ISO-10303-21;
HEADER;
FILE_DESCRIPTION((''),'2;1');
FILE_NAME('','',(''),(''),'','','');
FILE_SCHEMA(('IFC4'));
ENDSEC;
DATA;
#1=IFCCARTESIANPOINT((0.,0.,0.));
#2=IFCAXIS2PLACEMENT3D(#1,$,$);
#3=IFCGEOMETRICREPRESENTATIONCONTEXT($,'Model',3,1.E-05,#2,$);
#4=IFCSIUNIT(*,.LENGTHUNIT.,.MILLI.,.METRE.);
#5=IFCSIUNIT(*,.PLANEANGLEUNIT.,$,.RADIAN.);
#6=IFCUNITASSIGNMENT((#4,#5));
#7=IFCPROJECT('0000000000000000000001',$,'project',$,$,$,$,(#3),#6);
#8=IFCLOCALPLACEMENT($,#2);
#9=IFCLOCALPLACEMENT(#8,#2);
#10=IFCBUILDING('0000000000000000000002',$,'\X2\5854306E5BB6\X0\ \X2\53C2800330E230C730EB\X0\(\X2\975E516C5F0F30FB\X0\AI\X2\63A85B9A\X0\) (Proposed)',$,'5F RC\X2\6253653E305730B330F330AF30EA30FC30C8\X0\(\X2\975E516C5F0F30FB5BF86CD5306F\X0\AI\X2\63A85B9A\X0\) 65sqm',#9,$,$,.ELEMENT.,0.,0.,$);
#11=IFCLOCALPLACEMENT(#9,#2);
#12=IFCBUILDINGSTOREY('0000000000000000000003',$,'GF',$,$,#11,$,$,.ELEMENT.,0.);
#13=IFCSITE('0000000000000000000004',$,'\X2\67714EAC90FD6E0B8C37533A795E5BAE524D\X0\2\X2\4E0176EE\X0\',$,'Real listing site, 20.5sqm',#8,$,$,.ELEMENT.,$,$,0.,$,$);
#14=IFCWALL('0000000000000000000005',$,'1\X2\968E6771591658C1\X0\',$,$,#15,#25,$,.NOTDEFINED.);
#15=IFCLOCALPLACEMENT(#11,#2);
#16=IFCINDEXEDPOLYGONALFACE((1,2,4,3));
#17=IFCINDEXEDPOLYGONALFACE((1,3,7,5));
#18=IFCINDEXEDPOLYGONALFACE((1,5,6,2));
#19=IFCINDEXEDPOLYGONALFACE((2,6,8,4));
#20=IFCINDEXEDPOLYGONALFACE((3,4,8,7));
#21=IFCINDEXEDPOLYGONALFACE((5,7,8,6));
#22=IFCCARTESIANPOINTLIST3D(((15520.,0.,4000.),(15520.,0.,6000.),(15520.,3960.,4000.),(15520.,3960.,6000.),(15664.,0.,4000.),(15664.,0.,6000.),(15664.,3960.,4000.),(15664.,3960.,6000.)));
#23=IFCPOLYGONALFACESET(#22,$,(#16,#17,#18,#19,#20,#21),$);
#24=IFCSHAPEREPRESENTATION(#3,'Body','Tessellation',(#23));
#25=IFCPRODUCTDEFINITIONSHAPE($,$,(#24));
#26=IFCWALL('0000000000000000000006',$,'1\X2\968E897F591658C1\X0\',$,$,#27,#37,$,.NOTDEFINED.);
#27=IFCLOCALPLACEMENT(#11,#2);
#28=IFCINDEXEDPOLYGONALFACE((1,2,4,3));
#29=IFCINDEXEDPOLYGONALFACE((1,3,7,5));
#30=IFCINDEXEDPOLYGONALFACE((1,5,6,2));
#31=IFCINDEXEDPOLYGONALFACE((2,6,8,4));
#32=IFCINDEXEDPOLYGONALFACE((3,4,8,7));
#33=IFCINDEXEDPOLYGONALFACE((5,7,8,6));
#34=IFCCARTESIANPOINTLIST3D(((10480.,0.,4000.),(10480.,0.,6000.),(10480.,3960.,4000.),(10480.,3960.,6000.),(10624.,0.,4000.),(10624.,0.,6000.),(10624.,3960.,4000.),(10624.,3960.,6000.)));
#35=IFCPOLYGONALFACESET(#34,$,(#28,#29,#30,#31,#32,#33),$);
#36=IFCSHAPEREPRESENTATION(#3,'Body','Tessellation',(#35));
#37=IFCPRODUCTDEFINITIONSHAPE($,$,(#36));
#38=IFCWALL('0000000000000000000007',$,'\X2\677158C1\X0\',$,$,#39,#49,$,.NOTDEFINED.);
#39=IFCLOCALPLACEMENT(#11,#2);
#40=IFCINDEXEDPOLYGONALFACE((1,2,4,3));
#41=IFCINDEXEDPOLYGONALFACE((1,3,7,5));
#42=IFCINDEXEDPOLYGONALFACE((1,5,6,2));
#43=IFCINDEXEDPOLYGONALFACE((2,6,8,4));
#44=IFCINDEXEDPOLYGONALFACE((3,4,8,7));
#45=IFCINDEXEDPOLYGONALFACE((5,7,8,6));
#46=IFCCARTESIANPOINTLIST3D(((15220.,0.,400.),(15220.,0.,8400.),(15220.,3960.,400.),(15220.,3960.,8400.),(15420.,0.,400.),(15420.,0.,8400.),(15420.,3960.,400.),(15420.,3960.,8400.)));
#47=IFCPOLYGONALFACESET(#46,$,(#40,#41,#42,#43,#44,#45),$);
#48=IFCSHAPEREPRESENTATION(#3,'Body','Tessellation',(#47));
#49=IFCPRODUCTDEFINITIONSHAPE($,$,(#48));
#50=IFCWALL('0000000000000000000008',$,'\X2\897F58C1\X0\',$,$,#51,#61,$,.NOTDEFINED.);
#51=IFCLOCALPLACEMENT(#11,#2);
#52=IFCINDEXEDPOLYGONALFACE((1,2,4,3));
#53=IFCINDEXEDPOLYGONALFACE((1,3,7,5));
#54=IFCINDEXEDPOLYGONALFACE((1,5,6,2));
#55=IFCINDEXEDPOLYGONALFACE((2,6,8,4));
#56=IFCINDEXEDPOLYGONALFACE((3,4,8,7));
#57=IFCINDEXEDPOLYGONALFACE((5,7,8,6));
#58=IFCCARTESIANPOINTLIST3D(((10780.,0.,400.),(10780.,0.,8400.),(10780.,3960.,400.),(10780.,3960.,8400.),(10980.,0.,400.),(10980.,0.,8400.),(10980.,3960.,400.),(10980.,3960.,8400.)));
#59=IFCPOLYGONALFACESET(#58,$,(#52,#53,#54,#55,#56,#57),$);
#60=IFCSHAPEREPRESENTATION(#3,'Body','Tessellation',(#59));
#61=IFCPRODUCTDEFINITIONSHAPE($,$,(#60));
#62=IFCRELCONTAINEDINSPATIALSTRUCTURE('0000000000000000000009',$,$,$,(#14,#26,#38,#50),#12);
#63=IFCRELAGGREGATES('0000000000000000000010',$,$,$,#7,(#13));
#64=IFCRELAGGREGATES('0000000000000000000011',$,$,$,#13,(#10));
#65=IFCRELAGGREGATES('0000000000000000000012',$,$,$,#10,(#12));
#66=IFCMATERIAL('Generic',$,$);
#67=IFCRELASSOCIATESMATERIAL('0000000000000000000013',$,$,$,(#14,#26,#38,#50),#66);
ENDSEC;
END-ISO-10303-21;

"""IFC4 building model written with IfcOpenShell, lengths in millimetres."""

from ifc_helpers import new_model, si_unit, frame, frame_2d, origin, place, context, project, spatial, rectangle, extrude, material, element, save


model = new_model("IFC4")

# Units and contexts
model_context = context("Model", 3, precision=1e-05, world=origin())
ifc_project = project(units=[si_unit("LENGTHUNIT", "METRE", prefix="MILLI"), si_unit("PLANEANGLEUNIT", "RADIAN")], contexts=[model_context])

# Site, building, storey
site_placement = place(None, origin())
site = spatial("IfcSite", under=ifc_project, at=site_placement, Name="東京都渋谷区神宮前2丁目", ObjectType="Real listing site, 20.5sqm", CompositionType="ELEMENT", RefElevation=0.0)
building_placement = place(site_placement, origin())
building = spatial("IfcBuilding", under=site, at=building_placement, Name="塔の家 参考モデル(非公式・AI推定) (Proposed)", ObjectType="5F RC打放しコンクリート(非公式・寸法はAI推定) 65sqm", CompositionType="ELEMENT", ElevationOfRefHeight=0.0, ElevationOfTerrain=0.0)
storey_placement = place(building_placement, origin())
storey = spatial("IfcBuildingStorey", under=building, at=storey_placement, Name="GF", CompositionType="ELEMENT", Elevation=0.0)

# Shared definitions
ifc_material = material(Name="Generic")

# Walls
wall_1_placement = place(storey_placement, frame((7760.0, 0.0, 2000.0)))
element("IfcWall", 1, at=wall_1_placement, inside=storey, material=ifc_material, Name="1階東外壁", PredefinedType="NOTDEFINED", context=model_context, shape_type="SweptSolid", body=[
    extrude(rectangle(XDim=144.0, YDim=3960.0, at=frame_2d((72.0, 1980.0))), frame((7760.0, 0.0, 2000.0)), (0.0, 0.0, 1.0), 2000.0),
])
wall_2_placement = place(storey_placement, frame((5240.0, 0.0, 2000.0)))
element("IfcWall", 2, at=wall_2_placement, inside=storey, material=ifc_material, Name="1階西外壁", PredefinedType="NOTDEFINED", context=model_context, shape_type="SweptSolid", body=[
    extrude(rectangle(XDim=144.0, YDim=3960.0, at=frame_2d((72.0, 1980.0))), frame((5240.0, 0.0, 2000.0)), (0.0, 0.0, 1.0), 2000.0),
])

# Walls
wall_3_placement = place(storey_placement, frame((7610.0, 0.0, 200.0)))
element("IfcWall", 3, at=wall_3_placement, inside=storey, material=ifc_material, Name="東壁", PredefinedType="NOTDEFINED", context=model_context, shape_type="SweptSolid", body=[
    extrude(rectangle(XDim=200.0, YDim=3960.0, at=frame_2d((100.0, 1980.0))), frame((7610.0, 0.0, 200.0)), (0.0, 0.0, 1.0), 8000.0),
])
wall_4_placement = place(storey_placement, frame((5390.0, 0.0, 200.0)))
element("IfcWall", 4, at=wall_4_placement, inside=storey, material=ifc_material, Name="西壁", PredefinedType="NOTDEFINED", context=model_context, shape_type="SweptSolid", body=[
    extrude(rectangle(XDim=200.0, YDim=3960.0, at=frame_2d((100.0, 1980.0))), frame((5390.0, 0.0, 200.0)), (0.0, 0.0, 1.0), 8000.0),
])

save(model, "model.ifc")
